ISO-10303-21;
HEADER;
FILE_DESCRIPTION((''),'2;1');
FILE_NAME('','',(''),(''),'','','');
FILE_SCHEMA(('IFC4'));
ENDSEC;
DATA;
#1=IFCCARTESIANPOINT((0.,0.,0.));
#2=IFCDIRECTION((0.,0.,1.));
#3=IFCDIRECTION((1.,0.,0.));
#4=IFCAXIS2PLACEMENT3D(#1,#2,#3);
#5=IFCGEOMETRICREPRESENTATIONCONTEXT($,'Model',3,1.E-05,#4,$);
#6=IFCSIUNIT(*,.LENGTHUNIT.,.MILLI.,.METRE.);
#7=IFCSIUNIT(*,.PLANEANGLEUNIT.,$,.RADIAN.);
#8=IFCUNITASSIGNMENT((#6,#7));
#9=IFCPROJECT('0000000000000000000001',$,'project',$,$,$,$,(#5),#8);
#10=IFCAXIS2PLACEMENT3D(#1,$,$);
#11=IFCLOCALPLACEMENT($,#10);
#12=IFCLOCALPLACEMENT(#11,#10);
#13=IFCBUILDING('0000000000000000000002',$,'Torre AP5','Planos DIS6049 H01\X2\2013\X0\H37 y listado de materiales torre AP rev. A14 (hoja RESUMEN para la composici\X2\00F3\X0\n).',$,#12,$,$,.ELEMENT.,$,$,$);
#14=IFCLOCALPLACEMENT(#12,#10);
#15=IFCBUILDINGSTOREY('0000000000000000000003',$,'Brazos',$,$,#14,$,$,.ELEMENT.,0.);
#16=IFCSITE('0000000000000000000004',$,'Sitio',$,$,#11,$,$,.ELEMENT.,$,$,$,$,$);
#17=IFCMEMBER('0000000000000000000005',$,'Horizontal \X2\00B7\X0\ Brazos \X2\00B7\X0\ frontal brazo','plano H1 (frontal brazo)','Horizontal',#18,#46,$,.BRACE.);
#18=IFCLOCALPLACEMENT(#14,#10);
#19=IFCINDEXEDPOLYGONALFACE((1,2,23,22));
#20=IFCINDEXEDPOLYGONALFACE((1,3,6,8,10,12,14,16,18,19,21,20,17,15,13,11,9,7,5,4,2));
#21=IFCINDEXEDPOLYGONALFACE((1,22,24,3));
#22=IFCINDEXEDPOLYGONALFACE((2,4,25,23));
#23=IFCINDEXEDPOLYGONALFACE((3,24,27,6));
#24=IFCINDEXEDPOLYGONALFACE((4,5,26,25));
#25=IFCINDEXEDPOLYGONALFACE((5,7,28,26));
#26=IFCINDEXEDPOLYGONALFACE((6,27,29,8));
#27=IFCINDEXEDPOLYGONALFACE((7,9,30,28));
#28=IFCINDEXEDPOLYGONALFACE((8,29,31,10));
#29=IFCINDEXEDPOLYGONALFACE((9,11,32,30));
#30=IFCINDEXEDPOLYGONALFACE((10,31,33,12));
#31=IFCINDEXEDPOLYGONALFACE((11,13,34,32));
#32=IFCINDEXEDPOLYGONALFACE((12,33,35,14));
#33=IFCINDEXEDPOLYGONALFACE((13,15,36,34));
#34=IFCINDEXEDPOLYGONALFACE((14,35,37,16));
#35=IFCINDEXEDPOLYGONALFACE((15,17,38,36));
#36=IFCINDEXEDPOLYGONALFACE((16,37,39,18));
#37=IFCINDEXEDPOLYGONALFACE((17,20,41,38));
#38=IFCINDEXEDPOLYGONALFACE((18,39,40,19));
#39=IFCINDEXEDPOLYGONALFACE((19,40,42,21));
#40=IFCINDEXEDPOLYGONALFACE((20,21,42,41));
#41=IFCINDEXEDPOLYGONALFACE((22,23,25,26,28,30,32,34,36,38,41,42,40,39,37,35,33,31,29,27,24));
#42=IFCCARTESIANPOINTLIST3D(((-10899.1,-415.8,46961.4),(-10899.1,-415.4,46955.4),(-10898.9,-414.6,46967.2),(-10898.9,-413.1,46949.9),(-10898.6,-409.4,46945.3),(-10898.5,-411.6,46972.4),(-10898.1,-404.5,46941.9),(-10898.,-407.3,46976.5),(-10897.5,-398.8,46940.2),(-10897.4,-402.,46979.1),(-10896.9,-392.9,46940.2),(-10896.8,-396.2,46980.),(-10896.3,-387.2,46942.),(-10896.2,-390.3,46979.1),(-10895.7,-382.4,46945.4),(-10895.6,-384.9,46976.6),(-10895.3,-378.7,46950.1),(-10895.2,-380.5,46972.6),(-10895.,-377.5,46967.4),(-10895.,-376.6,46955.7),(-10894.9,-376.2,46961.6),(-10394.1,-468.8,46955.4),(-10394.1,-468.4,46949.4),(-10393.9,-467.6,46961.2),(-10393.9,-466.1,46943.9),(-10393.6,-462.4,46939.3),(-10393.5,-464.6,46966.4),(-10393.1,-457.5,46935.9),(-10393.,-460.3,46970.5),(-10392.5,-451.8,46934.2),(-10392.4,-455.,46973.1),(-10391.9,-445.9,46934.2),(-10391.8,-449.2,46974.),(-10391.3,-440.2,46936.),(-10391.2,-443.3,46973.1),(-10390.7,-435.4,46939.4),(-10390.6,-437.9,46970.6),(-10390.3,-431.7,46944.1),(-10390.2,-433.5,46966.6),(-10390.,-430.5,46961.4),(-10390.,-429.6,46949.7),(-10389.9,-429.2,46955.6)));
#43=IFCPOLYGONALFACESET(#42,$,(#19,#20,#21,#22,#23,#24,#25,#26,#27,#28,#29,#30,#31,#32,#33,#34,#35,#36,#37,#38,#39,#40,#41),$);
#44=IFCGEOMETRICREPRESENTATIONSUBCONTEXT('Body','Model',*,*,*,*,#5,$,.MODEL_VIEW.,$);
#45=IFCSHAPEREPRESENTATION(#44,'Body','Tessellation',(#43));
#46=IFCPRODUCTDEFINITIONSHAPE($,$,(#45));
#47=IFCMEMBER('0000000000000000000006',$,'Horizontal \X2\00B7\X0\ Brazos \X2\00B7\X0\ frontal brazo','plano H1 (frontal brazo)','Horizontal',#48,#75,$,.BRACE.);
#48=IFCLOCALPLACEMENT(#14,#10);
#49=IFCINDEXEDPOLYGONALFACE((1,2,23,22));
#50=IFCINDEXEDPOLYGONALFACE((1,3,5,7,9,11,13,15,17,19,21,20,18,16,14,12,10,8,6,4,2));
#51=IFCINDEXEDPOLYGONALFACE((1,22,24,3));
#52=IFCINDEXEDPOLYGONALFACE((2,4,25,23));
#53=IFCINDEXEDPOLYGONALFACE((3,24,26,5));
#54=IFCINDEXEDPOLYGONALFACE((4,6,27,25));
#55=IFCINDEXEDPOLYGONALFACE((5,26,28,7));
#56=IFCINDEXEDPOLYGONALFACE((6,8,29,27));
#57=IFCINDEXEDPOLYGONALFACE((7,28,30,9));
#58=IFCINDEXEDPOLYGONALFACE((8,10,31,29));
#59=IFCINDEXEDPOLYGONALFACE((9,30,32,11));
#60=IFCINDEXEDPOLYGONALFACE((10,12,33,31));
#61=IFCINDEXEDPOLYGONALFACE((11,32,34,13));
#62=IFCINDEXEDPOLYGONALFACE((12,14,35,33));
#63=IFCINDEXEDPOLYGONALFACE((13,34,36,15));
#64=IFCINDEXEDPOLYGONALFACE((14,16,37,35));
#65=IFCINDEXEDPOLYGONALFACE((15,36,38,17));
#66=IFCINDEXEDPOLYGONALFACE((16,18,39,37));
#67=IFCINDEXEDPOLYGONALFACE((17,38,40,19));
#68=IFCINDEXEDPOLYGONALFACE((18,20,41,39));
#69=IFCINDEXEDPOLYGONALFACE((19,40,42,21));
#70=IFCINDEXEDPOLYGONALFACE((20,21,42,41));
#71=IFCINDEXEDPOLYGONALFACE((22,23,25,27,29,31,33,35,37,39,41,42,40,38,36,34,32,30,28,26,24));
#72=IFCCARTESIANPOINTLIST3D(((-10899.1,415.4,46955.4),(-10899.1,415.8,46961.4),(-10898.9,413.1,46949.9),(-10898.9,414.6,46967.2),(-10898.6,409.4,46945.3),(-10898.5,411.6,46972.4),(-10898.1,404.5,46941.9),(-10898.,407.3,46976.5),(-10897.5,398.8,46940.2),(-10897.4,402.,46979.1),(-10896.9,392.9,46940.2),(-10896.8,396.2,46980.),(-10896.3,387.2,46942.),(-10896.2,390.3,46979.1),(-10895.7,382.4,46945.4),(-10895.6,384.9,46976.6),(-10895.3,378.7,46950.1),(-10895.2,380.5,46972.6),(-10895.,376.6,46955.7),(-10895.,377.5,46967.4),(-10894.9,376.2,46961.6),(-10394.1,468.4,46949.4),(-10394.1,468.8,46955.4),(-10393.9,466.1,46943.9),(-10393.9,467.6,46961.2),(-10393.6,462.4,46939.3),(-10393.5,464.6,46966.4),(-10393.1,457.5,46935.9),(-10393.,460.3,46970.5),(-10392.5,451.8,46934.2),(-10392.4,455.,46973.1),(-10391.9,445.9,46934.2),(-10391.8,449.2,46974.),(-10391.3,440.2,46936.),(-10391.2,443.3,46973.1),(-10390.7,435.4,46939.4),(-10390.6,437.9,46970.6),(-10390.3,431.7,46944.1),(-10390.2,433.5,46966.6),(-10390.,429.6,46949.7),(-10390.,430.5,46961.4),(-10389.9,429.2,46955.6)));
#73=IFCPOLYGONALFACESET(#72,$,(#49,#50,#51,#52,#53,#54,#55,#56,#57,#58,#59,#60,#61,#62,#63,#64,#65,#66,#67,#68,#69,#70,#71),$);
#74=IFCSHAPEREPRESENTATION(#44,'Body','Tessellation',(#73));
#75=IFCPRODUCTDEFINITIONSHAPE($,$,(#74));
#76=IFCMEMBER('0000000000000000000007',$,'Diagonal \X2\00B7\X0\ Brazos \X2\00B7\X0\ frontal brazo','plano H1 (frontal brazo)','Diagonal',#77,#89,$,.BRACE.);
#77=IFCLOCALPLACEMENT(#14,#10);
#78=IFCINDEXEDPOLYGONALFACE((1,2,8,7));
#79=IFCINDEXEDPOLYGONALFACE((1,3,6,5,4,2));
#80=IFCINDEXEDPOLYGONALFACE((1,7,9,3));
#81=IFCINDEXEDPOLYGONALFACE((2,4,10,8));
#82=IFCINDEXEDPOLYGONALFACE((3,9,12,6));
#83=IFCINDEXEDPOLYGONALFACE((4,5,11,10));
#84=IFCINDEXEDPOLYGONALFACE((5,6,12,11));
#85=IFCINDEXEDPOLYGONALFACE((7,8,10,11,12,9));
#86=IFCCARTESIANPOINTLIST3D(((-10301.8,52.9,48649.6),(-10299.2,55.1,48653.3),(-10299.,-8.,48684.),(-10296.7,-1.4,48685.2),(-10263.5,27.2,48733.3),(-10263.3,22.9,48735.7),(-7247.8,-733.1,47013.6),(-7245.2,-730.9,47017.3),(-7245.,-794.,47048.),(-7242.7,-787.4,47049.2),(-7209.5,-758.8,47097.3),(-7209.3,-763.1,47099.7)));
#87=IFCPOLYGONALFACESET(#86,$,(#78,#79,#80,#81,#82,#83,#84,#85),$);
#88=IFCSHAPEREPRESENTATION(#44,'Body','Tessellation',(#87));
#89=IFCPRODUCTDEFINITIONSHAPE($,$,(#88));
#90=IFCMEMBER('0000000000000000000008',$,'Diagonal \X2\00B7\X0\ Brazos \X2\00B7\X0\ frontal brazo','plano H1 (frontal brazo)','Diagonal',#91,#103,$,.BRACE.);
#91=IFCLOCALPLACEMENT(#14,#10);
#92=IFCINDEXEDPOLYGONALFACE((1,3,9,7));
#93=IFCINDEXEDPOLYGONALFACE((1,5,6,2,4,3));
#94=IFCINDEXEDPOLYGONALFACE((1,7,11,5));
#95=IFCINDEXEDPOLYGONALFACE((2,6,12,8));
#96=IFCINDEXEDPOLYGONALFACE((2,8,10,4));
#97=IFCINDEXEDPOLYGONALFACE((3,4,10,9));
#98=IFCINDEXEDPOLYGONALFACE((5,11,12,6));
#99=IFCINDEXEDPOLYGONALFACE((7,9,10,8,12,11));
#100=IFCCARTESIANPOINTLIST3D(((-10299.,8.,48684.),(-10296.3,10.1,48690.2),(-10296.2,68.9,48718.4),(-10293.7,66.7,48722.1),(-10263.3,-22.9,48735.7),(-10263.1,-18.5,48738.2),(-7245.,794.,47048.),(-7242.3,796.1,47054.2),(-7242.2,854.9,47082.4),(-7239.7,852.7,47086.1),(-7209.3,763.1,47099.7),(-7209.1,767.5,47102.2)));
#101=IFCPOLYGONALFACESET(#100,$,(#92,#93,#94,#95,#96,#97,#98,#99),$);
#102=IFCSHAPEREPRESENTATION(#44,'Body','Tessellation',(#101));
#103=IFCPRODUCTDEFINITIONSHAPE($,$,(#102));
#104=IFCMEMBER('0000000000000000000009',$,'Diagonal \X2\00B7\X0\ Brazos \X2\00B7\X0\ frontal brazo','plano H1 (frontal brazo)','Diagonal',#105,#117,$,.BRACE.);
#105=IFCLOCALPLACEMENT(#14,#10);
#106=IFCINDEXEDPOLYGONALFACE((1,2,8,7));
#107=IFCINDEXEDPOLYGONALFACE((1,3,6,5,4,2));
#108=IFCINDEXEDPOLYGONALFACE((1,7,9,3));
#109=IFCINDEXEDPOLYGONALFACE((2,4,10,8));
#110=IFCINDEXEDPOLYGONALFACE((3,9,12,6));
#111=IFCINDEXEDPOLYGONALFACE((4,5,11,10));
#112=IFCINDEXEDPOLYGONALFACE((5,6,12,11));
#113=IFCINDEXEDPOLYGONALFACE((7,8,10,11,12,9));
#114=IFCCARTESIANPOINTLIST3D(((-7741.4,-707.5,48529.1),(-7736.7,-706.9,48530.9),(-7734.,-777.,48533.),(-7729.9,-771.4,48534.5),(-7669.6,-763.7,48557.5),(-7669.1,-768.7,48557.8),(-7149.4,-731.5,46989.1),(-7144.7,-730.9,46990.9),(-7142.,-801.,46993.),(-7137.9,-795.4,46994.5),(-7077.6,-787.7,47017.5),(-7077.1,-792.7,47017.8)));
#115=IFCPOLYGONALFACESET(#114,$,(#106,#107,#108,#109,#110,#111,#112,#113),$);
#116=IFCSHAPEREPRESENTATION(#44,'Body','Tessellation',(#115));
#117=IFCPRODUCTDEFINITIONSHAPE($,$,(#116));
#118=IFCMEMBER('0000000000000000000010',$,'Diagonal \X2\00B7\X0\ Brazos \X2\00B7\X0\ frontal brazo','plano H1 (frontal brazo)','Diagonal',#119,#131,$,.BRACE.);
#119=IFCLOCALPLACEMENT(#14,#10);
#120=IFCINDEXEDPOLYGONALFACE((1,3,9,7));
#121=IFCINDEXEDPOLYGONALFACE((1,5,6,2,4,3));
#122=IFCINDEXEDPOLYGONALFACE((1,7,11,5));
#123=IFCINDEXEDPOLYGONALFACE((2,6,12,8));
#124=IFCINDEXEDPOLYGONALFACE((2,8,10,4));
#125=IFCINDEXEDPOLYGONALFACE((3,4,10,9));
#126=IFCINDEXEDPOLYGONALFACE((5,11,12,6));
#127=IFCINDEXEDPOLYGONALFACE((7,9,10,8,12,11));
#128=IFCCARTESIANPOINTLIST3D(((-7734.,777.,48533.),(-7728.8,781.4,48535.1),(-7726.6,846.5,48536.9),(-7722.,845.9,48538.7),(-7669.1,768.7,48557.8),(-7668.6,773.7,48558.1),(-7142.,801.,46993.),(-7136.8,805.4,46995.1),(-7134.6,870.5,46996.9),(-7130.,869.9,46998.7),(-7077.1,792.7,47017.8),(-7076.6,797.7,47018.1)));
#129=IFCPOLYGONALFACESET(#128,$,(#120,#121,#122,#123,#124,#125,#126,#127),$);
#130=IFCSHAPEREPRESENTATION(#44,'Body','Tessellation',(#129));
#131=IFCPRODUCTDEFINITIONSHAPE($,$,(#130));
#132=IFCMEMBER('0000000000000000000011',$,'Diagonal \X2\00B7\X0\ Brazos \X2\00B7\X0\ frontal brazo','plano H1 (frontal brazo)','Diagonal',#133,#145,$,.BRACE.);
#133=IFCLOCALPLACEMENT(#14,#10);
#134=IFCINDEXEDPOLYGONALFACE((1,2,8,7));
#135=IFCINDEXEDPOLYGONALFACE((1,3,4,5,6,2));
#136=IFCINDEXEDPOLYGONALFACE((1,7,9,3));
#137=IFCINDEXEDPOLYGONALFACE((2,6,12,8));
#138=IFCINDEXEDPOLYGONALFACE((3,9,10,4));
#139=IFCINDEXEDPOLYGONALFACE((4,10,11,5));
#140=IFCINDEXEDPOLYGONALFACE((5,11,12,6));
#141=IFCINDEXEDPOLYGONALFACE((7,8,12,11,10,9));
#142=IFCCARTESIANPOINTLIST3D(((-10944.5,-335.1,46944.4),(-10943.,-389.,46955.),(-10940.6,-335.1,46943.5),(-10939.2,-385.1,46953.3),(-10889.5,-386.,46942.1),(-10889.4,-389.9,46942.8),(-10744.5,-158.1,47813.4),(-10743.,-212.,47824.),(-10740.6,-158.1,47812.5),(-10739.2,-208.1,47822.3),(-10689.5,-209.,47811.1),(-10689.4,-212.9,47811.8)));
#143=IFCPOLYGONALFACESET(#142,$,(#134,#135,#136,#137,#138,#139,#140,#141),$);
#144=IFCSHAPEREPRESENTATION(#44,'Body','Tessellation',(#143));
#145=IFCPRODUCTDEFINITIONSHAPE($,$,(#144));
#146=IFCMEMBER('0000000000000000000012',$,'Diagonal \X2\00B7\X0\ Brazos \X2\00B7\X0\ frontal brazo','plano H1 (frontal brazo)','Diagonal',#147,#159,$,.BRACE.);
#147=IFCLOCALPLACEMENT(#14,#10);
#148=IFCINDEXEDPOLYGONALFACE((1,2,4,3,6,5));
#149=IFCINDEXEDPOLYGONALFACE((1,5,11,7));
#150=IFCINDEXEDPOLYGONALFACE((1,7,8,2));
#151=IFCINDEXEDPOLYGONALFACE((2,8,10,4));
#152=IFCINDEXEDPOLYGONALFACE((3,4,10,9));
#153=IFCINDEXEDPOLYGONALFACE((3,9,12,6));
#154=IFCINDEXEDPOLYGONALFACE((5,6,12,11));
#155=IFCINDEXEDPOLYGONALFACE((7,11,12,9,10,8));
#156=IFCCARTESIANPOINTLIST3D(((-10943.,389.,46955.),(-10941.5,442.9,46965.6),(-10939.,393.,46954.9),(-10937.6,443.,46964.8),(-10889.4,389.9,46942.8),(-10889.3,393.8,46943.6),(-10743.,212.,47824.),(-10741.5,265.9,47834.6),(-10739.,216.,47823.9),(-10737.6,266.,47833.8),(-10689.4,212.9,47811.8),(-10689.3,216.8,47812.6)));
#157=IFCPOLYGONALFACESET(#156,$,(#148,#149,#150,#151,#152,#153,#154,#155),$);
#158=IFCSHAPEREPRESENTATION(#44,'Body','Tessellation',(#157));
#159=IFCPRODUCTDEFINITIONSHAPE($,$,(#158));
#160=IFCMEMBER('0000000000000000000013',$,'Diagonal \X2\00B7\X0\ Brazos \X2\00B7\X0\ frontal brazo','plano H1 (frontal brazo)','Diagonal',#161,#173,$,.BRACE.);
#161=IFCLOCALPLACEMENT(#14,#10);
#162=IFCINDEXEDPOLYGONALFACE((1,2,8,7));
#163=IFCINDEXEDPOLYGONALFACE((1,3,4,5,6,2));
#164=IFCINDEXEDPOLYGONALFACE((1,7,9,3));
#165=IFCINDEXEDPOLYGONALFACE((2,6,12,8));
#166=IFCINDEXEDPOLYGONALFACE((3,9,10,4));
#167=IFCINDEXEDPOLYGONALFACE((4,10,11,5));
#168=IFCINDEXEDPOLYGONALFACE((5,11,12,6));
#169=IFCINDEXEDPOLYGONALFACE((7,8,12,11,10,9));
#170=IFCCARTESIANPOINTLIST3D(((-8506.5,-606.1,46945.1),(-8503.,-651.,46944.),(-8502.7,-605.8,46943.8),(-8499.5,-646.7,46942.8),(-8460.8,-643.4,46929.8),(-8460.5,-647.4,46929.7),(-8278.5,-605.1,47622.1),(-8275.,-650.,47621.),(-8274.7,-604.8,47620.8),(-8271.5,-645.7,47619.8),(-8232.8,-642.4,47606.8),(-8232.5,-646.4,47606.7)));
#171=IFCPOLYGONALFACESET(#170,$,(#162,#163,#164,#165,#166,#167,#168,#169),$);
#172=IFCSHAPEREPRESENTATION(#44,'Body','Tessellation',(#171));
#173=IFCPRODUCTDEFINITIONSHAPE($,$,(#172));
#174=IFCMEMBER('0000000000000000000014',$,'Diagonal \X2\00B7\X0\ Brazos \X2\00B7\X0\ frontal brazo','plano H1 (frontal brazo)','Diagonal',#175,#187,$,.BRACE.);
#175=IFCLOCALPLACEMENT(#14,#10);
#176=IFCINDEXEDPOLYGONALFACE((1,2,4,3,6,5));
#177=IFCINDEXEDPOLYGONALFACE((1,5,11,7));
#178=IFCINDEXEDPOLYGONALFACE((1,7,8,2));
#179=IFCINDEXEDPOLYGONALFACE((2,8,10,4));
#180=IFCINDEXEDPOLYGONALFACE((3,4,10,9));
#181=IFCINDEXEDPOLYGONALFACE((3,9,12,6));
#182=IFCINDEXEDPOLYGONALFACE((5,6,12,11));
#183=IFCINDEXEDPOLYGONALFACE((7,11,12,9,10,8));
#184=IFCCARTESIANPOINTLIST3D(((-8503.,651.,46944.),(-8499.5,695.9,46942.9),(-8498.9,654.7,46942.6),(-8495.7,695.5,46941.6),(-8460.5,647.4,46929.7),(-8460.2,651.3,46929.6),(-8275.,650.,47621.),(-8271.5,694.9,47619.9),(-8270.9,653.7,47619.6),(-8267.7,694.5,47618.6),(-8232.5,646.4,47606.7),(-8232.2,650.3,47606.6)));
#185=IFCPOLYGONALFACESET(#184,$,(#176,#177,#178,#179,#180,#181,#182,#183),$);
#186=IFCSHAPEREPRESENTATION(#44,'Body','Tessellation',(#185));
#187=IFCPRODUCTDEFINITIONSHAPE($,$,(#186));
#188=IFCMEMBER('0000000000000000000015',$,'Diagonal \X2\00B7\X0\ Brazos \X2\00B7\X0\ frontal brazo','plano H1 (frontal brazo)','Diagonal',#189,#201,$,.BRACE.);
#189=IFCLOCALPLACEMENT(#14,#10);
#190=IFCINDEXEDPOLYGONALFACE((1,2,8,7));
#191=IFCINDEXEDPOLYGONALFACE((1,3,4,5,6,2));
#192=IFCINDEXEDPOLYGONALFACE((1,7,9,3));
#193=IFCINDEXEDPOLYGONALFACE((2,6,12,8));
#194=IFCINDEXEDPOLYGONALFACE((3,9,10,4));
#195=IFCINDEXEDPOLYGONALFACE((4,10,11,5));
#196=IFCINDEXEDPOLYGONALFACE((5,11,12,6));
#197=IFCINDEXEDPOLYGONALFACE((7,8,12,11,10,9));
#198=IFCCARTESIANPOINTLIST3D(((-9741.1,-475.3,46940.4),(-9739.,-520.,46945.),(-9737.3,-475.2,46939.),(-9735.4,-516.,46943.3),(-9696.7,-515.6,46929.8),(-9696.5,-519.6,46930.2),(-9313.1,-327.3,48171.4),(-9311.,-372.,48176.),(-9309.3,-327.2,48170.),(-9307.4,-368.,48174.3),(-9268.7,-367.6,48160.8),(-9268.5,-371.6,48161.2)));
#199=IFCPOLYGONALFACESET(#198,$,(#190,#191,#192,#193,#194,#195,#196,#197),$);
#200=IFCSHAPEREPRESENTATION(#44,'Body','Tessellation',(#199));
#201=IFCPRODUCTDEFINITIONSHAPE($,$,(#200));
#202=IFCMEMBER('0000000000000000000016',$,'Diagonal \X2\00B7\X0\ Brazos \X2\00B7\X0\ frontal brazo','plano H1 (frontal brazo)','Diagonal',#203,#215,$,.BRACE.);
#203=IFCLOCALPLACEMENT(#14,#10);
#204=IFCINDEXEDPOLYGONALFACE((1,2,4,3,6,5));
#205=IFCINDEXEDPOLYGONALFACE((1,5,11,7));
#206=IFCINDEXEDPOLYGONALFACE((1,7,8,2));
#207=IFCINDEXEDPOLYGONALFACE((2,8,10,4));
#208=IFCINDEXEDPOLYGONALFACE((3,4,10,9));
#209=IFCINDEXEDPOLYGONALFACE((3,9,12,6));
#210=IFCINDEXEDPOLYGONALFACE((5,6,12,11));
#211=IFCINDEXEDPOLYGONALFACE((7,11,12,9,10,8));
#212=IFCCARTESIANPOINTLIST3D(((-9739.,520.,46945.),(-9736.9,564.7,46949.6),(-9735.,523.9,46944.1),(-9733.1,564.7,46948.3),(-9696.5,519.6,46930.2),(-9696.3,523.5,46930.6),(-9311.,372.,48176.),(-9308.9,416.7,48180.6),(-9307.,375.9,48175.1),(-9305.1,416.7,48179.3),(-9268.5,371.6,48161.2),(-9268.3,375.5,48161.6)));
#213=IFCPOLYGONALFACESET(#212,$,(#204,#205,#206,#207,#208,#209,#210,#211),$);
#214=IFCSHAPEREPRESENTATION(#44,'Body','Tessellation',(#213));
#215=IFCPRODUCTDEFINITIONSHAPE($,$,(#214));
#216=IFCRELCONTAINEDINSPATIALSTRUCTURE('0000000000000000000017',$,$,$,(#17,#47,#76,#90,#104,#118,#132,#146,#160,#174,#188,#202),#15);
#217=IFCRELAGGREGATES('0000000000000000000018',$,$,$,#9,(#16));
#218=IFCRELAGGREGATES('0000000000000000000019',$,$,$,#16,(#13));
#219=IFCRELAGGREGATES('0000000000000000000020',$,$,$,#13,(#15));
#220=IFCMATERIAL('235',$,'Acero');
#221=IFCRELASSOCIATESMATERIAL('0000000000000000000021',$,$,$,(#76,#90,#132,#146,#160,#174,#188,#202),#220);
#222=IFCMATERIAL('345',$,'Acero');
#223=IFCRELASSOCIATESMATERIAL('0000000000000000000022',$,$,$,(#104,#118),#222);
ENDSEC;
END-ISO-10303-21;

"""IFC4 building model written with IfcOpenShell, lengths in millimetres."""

from ifc_helpers import new_model, si_unit, frame, frame_2d, origin, origin_with_axes, place, context, subcontext, project, spatial, circle, l_section, extrude, material, element, save


model = new_model("IFC4")

# Units and contexts
model_context = context("Model", 3, precision=1e-05, world=origin_with_axes())
body_context = subcontext(model_context, "Body", "Model", "MODEL_VIEW")
ifc_project = project(units=[si_unit("LENGTHUNIT", "METRE", prefix="MILLI"), si_unit("PLANEANGLEUNIT", "RADIAN")], contexts=[model_context])

# Site, building, storey
site_placement = place(None, origin())
site = spatial("IfcSite", under=ifc_project, at=site_placement, Name="Sitio", CompositionType="ELEMENT")
building_placement = place(site_placement, origin())
building = spatial("IfcBuilding", under=site, at=building_placement, Name="Torre AP5", Description="Planos DIS6049 H01–H37 y listado de materiales torre AP rev. A14 (hoja RESUMEN para la composición).", CompositionType="ELEMENT")
storey_placement = place(building_placement, origin())
storey = spatial("IfcBuildingStorey", under=building, at=storey_placement, Name="Brazos", CompositionType="ELEMENT", Elevation=0.0)

# Members
for number, where, z_axis, x_axis, name in (
    (1, (-10392.0, -449.0, 46954.0), (-0.994468, 0.10437, 0.011815), (0.104986, 0.991163, 0.081074), "Horizontal · Brazos · frontal brazo"),
    (2, (-10392.0, 449.0, 46954.0), (-0.994468, -0.10437, 0.011815), (0.104986, -0.991163, 0.081074), "Horizontal · Brazos · frontal brazo"),
):
    element("IfcMember", number, at=place(storey_placement, frame(where, z_axis=z_axis, x_axis=x_axis)), inside=storey, Name=name, Description="plano H1 (frontal brazo)", ObjectType="Horizontal", PredefinedType="BRACE", context=body_context, shape_type="SweptSolid", body=[
        extrude(circle(Radius=20.0), None, (0.0, 0.0, 1.0), 507.8),
    ])
ifc_material_1 = material(Name="235", Category="Acero")
for number, where, z_axis, x_axis, name in (
    (3, (-7245.0, -794.0, 47048.0), (-0.859644, 0.221244, 0.460503), (0.509345, 0.441284, 0.738808), "Diagonal · Brazos · frontal brazo"),
    (4, (-7245.0, 794.0, 47048.0), (-0.859644, -0.221244, 0.460503), (0.509345, -0.441284, 0.738808), "Diagonal · Brazos · frontal brazo"),
):
    element("IfcMember", number, at=place(storey_placement, frame(where, z_axis=z_axis, x_axis=x_axis)), inside=storey, material=ifc_material_1, Name=name, Description="plano H1 (frontal brazo)", ObjectType="Diagonal", PredefinedType="BRACE", context=body_context, shape_type="SweptSolid", body=[
        extrude(l_section(Depth=70.0, Width=70.0, Thickness=5.0, at=frame_2d((35.0, 35.0))), None, (0.0, 0.0, 1.0), 3552.6),
    ])
ifc_material_2 = material(Name="345", Category="Acero")
for number, where, z_axis, x_axis, name in (
    (5, (-7142.0, -801.0, 46993.0), (-0.358779, 0.014545, 0.933309), (0.927462, 0.118373, 0.354686), "Diagonal · Brazos · frontal brazo"),
    (6, (-7142.0, 801.0, 46993.0), (-0.358779, -0.014545, 0.933309), (0.927462, -0.118373, 0.354686), "Diagonal · Brazos · frontal brazo"),
):
    element("IfcMember", number, at=place(storey_placement, frame(where, z_axis=z_axis, x_axis=x_axis)), inside=storey, material=ifc_material_2, Name=name, Description="plano H1 (frontal brazo)", ObjectType="Diagonal", PredefinedType="BRACE", context=body_context, shape_type="SweptSolid", body=[
        extrude(l_section(Depth=70.0, Width=70.0, Thickness=5.0, at=frame_2d((35.0, 35.0))), None, (0.0, 0.0, 1.0), 1650.0),
    ])
for number, where, z_axis, x_axis, name in (
    (7, (-10943.0, -389.0, 46955.0), (0.219994, 0.194695, 0.955875), (0.975122, -0.016589, -0.221045), "Diagonal · Brazos · frontal brazo"),
    (8, (-10943.0, 389.0, 46955.0), (0.219994, -0.194695, 0.955875), (0.975122, 0.016589, -0.221045), "Diagonal · Brazos · frontal brazo"),
):
    element("IfcMember", number, at=place(storey_placement, frame(where, z_axis=z_axis, x_axis=x_axis)), inside=storey, material=ifc_material_1, Name=name, Description="plano H1 (frontal brazo)", ObjectType="Diagonal", PredefinedType="BRACE", context=body_context, shape_type="SweptSolid", body=[
        extrude(l_section(Depth=55.0, Width=55.0, Thickness=4.0, at=frame_2d((27.5, 27.5))), None, (0.0, 0.0, 1.0), 909.1),
    ])
for number, where, z_axis, x_axis, name in (
    (9, (-8503.0, -651.0, 46944.0), (0.319166, 0.0014, 0.947698), (0.944542, 0.081082, -0.318223), "Diagonal · Brazos · frontal brazo"),
    (10, (-8503.0, 651.0, 46944.0), (0.319166, -0.0014, 0.947698), (0.944542, -0.081082, -0.318223), "Diagonal · Brazos · frontal brazo"),
):
    element("IfcMember", number, at=place(storey_placement, frame(where, z_axis=z_axis, x_axis=x_axis)), inside=storey, material=ifc_material_1, Name=name, Description="plano H1 (frontal brazo)", ObjectType="Diagonal", PredefinedType="BRACE", context=body_context, shape_type="SweptSolid", body=[
        extrude(l_section(Depth=45.0, Width=45.0, Thickness=4.0, at=frame_2d((22.5, 22.5))), None, (0.0, 0.0, 1.0), 714.4),
    ])
for number, where, z_axis, x_axis, name in (
    (11, (-9739.0, -520.0, 46945.0), (0.326304, 0.112834, 0.938506), (0.944119, 0.009962, -0.329454), "Diagonal · Brazos · frontal brazo"),
    (12, (-9739.0, 520.0, 46945.0), (0.326304, -0.112834, 0.938506), (0.944119, -0.009962, -0.329454), "Diagonal · Brazos · frontal brazo"),
):
    element("IfcMember", number, at=place(storey_placement, frame(where, z_axis=z_axis, x_axis=x_axis)), inside=storey, material=ifc_material_1, Name=name, Description="plano H1 (frontal brazo)", ObjectType="Diagonal", PredefinedType="BRACE", context=body_context, shape_type="SweptSolid", body=[
        extrude(l_section(Depth=45.0, Width=45.0, Thickness=4.0, at=frame_2d((22.5, 22.5))), None, (0.0, 0.0, 1.0), 1311.7),
    ])

save(model, "model.ifc")
